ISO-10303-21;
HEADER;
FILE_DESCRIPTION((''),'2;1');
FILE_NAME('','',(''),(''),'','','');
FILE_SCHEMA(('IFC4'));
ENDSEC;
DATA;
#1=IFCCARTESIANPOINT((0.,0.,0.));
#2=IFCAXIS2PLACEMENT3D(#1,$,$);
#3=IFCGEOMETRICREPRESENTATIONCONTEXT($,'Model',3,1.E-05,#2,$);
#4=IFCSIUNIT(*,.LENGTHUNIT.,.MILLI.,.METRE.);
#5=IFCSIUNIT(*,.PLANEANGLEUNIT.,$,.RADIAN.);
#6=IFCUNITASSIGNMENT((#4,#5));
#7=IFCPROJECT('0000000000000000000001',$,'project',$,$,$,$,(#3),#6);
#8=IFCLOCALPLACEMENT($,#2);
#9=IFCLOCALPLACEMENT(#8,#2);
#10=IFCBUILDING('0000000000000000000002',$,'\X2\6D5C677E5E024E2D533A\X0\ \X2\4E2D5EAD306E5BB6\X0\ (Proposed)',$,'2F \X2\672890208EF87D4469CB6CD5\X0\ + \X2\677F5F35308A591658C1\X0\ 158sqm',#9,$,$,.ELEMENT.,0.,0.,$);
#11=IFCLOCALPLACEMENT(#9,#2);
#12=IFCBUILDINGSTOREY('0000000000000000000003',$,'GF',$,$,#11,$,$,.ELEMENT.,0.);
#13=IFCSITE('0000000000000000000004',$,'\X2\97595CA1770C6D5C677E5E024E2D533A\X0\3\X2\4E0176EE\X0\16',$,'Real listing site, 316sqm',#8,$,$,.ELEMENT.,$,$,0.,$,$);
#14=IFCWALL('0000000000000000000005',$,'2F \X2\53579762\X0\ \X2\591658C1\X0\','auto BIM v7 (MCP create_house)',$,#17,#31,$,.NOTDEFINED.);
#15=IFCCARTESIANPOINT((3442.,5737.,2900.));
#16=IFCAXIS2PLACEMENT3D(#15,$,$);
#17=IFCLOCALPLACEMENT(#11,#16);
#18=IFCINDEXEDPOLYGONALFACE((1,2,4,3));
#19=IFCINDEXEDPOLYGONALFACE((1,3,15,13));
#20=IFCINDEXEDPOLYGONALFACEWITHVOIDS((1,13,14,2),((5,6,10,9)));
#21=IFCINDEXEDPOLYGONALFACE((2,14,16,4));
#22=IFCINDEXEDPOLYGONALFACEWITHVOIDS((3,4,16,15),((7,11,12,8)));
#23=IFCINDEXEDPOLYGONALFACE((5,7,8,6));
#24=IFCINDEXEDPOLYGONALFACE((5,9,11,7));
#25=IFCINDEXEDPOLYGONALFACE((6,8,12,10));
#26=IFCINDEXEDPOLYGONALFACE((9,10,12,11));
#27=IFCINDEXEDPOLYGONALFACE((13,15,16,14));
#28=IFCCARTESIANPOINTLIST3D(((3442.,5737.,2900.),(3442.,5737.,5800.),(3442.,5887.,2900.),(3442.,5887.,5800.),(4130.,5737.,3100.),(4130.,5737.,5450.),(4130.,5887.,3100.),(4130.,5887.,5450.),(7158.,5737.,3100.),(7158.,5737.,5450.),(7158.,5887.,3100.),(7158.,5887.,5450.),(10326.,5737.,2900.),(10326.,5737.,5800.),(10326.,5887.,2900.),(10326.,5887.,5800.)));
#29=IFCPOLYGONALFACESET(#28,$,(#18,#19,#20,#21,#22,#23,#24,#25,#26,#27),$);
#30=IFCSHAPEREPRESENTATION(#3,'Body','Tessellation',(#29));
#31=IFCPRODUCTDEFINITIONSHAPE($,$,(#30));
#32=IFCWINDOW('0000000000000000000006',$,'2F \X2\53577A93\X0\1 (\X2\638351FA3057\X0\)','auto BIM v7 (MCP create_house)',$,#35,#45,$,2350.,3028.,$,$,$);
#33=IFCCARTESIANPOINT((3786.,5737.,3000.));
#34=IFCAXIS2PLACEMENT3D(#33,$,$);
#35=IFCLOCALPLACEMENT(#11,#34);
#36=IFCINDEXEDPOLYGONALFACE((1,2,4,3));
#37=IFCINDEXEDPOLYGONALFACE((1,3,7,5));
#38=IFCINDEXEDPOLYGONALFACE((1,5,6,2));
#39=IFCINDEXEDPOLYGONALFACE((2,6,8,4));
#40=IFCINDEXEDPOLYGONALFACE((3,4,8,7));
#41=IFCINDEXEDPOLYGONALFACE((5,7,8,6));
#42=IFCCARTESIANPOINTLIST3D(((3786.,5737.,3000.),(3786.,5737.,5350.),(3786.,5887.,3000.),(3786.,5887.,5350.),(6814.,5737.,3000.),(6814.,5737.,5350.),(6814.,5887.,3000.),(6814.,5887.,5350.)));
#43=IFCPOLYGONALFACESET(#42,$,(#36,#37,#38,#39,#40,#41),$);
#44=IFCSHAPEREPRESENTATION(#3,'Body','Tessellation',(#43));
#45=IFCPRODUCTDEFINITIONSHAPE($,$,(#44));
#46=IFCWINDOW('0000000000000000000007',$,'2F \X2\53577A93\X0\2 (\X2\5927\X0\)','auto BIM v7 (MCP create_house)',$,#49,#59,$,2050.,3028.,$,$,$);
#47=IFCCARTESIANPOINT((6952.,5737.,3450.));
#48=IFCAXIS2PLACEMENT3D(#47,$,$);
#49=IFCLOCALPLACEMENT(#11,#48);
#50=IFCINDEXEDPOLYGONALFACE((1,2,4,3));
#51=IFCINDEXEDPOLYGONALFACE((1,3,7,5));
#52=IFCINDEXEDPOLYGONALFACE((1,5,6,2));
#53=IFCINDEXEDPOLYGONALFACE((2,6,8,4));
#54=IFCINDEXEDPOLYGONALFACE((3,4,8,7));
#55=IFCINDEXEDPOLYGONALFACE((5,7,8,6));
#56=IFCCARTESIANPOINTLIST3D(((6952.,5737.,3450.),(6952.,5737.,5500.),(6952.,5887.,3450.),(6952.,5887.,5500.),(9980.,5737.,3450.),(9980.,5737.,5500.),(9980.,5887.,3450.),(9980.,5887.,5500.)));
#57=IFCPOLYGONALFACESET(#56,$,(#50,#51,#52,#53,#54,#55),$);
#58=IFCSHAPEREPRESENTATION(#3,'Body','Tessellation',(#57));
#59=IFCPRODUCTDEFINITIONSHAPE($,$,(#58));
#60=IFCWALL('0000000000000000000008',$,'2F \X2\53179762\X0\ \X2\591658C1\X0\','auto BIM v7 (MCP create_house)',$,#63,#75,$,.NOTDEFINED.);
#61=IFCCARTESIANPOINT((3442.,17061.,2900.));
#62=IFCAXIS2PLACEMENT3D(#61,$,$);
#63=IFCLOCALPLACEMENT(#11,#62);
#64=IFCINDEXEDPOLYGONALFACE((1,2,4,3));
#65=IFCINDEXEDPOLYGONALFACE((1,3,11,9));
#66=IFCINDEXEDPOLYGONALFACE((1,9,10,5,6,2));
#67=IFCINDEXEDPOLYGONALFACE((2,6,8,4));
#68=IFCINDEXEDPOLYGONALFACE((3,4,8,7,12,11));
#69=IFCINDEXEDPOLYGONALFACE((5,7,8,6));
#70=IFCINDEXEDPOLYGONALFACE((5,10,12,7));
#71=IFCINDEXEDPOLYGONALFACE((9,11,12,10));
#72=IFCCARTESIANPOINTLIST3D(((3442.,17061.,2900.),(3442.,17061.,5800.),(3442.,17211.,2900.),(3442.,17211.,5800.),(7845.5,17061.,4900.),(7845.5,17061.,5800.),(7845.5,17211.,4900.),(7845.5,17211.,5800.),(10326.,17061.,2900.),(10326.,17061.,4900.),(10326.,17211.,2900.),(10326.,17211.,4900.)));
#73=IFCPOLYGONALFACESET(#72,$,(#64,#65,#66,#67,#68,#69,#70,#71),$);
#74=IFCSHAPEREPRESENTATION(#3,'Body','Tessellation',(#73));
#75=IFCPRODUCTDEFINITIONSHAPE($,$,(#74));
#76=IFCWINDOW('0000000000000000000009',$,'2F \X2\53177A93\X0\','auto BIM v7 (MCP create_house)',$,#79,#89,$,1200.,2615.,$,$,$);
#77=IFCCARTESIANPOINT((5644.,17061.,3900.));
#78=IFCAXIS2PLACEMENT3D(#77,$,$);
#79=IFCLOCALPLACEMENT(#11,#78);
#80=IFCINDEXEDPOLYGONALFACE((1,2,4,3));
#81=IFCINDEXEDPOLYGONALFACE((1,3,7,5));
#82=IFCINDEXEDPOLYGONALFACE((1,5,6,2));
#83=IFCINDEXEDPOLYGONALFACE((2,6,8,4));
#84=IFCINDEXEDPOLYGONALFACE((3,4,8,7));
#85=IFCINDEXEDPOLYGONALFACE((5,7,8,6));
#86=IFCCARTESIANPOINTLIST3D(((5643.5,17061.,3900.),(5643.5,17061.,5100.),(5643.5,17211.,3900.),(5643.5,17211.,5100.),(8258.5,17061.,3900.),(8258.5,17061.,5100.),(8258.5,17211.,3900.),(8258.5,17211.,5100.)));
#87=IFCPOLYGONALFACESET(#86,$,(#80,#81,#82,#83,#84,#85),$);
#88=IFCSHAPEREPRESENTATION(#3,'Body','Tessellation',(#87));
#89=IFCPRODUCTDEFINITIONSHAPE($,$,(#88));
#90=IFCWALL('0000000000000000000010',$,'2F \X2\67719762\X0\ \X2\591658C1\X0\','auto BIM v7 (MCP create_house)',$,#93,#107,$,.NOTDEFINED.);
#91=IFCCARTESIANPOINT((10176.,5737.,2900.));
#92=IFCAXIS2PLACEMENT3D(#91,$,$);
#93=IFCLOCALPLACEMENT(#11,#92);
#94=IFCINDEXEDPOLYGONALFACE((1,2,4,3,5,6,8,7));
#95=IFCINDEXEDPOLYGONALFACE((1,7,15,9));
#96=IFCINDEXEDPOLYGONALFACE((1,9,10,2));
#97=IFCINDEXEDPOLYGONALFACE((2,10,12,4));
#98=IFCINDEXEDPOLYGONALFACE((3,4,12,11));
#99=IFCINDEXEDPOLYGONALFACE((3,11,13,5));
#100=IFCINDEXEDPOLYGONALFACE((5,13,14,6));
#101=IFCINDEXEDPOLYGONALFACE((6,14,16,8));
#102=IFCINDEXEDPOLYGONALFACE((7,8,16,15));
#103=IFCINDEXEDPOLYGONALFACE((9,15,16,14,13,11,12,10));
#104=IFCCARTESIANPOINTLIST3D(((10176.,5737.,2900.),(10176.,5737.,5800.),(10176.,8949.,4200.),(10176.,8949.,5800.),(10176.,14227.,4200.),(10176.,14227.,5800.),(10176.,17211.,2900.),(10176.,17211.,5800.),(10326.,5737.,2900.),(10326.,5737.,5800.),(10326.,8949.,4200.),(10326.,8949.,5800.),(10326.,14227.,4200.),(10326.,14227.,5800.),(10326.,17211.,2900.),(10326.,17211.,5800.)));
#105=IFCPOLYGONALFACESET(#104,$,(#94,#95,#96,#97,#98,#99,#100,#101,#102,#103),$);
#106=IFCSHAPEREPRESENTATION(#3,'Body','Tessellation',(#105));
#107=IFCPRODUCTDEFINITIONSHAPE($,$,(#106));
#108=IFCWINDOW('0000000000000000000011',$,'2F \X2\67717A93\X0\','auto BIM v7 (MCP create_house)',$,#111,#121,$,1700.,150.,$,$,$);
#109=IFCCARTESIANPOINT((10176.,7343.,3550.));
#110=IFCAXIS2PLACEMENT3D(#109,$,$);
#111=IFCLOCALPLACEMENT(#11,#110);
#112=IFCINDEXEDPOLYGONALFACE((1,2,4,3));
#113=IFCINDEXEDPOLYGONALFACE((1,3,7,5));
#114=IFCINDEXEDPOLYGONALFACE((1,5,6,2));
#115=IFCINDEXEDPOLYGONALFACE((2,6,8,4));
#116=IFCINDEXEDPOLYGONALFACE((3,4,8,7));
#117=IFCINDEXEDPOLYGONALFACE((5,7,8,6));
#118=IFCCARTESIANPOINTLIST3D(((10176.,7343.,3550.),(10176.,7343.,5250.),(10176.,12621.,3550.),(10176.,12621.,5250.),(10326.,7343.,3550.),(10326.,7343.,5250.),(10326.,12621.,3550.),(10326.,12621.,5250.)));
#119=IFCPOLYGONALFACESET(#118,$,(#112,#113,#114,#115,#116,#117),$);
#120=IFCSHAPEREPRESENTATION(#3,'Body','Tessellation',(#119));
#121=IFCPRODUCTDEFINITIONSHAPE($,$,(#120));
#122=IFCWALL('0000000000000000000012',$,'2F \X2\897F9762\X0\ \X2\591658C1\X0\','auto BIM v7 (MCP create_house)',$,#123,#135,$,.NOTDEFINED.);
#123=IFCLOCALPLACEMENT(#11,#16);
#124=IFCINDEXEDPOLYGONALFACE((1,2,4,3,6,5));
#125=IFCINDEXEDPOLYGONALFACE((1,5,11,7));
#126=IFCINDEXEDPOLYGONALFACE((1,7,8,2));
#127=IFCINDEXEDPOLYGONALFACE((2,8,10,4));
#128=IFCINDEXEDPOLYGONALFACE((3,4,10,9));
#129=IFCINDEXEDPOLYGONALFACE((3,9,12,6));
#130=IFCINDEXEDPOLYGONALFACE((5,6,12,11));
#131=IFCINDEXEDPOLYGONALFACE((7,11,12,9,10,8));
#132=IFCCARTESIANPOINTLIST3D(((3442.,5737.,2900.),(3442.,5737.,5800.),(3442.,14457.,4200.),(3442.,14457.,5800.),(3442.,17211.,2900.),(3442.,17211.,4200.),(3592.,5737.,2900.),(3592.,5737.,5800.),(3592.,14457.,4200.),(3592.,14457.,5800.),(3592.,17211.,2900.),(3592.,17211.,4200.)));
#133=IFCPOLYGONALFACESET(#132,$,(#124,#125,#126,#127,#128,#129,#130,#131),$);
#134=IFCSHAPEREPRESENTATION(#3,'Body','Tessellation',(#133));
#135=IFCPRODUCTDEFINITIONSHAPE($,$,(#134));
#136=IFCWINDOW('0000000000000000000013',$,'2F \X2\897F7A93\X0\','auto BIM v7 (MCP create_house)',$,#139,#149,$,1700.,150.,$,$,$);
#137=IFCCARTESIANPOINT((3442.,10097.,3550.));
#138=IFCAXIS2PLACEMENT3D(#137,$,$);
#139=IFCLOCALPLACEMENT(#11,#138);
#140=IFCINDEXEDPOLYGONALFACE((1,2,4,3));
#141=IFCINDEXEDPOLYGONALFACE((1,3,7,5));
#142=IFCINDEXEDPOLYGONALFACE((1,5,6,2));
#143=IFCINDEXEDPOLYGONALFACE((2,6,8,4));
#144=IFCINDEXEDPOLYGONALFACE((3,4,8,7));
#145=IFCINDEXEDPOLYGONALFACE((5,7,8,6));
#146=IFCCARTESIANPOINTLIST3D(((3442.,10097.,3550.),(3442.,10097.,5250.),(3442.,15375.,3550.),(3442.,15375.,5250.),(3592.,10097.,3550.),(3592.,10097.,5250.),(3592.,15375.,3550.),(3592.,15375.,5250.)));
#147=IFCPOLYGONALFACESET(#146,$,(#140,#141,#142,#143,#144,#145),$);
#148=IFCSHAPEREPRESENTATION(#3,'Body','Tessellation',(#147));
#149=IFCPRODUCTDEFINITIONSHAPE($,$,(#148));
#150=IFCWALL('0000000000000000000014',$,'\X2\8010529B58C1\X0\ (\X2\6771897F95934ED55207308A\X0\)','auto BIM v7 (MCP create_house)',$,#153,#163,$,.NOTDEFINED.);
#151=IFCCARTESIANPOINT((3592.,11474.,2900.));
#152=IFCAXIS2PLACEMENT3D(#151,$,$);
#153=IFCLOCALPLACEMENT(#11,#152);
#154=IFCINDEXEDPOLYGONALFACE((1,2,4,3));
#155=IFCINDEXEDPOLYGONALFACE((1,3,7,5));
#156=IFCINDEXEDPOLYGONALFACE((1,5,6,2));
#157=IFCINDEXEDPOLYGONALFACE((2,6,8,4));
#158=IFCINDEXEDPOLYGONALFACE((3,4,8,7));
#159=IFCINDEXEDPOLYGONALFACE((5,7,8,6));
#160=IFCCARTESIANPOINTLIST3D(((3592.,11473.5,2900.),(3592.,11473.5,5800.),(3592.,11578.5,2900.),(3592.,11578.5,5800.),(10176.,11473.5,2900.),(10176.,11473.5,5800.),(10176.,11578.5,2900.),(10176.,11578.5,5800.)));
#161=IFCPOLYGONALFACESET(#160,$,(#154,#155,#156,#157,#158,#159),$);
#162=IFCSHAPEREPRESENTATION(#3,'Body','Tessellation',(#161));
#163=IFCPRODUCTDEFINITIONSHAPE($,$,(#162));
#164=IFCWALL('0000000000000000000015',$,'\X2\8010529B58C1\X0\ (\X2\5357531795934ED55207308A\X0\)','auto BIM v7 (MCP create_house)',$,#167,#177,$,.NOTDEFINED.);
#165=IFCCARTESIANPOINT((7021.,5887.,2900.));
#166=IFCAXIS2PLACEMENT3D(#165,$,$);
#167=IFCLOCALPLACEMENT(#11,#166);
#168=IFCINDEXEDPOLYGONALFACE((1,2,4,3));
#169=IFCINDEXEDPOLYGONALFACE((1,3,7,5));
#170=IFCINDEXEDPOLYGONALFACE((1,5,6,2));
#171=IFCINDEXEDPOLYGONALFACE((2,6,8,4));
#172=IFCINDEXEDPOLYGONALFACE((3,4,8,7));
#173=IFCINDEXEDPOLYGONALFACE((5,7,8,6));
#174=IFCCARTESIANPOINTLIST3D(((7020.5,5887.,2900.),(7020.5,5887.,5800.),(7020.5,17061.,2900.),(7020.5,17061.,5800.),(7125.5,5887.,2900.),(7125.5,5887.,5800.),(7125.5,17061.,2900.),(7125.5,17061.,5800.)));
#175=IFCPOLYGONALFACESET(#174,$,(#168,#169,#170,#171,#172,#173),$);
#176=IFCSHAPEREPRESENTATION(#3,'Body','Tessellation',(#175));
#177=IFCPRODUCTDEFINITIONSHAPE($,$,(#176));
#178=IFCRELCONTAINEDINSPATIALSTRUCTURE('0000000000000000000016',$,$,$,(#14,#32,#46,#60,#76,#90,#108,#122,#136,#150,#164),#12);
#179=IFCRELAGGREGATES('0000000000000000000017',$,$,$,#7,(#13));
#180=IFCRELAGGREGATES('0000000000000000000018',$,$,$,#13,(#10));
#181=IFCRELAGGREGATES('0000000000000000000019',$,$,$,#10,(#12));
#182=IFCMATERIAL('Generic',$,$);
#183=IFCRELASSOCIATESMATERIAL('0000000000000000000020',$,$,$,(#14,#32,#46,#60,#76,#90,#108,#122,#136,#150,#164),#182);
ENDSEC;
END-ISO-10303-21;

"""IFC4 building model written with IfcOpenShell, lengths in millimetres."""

from ifc_helpers import new_model, si_unit, frame, frame_2d, origin, place, context, project, spatial, rectangle, extrude, material, element, fill, save


model = new_model("IFC4")

# Units and contexts
model_context = context("Model", 3, precision=1e-05, world=origin())
ifc_project = project(units=[si_unit("LENGTHUNIT", "METRE", prefix="MILLI"), si_unit("PLANEANGLEUNIT", "RADIAN")], contexts=[model_context])

# Site, building, storey
site_placement = place(None, origin())
site = spatial("IfcSite", under=ifc_project, at=site_placement, Name="静岡県浜松市中区3丁目16", ObjectType="Real listing site, 316sqm", CompositionType="ELEMENT", RefElevation=0.0)
building_placement = place(site_placement, origin())
building = spatial("IfcBuilding", under=site, at=building_placement, Name="浜松市中区 中庭の家 (Proposed)", ObjectType="2F 木造軸組構法 + 板張り外壁 158sqm", CompositionType="ELEMENT", ElevationOfRefHeight=0.0, ElevationOfTerrain=0.0)
storey_placement = place(building_placement, origin())
storey = spatial("IfcBuildingStorey", under=building, at=storey_placement, Name="GF", CompositionType="ELEMENT", Elevation=0.0)

# Shared definitions
ifc_material = material(Name="Generic")

# Wall, openings, windows
wall_1_placement = place(storey_placement, frame((3442.0, 5737.0, 2900.0)))
wall_1 = element("IfcWall", 1, at=wall_1_placement, inside=storey, material=ifc_material, Name="2F 南面 外壁", Description="auto BIM v7 (MCP create_house)", PredefinedType="NOTDEFINED", context=model_context, shape_type="SweptSolid", body=[
    extrude(rectangle(XDim=6884.0, YDim=150.0, at=frame_2d((3442.0, 75.0))), frame((3442.0, 5737.0, 2900.0)), (0.0, 0.0, 1.0), 2900.0),
])
opening_1_placement = place(storey_placement, frame((3786.0, 5737.0, 3000.0)))
opening_1 = element("IfcOpeningElement", 2, at=opening_1_placement, cuts=wall_1, PredefinedType="NOTDEFINED", context=model_context, shape_type="SweptSolid", body=[
    extrude(rectangle(XDim=3028.0, YDim=150.0, at=frame_2d((1514.0, 75.0))), frame((3786.0, 5737.0, 3000.0)), (0.0, 0.0, 1.0), 2350.0),
])
opening_2_placement = place(storey_placement, frame((6952.0, 5737.0, 3450.0)))
opening_2 = element("IfcOpeningElement", 3, at=opening_2_placement, cuts=wall_1, PredefinedType="NOTDEFINED", context=model_context, shape_type="SweptSolid", body=[
    extrude(rectangle(XDim=3028.0, YDim=150.0, at=frame_2d((1514.0, 75.0))), frame((6952.0, 5737.0, 3450.0)), (0.0, 0.0, 1.0), 2050.0),
])
window_1_placement = place(storey_placement, frame((3786.0, 5737.0, 3000.0)))
window_1 = element("IfcWindow", 4, at=window_1_placement, inside=storey, material=ifc_material, Name="2F 南窓1 (掃出し)", Description="auto BIM v7 (MCP create_house)", OverallHeight=2350.0, OverallWidth=3028.0, context=model_context, shape_type="SweptSolid", body=[
    extrude(rectangle(XDim=3028.0, YDim=150.0, at=frame_2d((1514.0, 75.0))), frame((3786.0, 5737.0, 3000.0)), (0.0, 0.0, 1.0), 2350.0),
])
fill(opening_1, window_1)
window_2_placement = place(storey_placement, frame((6952.0, 5737.0, 3450.0)))
window_2 = element("IfcWindow", 5, at=window_2_placement, inside=storey, material=ifc_material, Name="2F 南窓2 (大)", Description="auto BIM v7 (MCP create_house)", OverallHeight=2050.0, OverallWidth=3028.0, context=model_context, shape_type="SweptSolid", body=[
    extrude(rectangle(XDim=3028.0, YDim=150.0, at=frame_2d((1514.0, 75.0))), frame((6952.0, 5737.0, 3450.0)), (0.0, 0.0, 1.0), 2050.0),
])
fill(opening_2, window_2)

# Walls, openings, windows
wall_2_placement = place(storey_placement, frame((3442.0, 17061.0, 2900.0)))
wall_2 = element("IfcWall", 6, at=wall_2_placement, inside=storey, material=ifc_material, Name="2F 北面 外壁", Description="auto BIM v7 (MCP create_house)", PredefinedType="NOTDEFINED", context=model_context, shape_type="SweptSolid", body=[
    extrude(rectangle(XDim=6884.0, YDim=150.0, at=frame_2d((3442.0, 75.0))), frame((3442.0, 17061.0, 2900.0)), (0.0, 0.0, 1.0), 2900.0),
])
opening_3_placement = place(storey_placement, frame((5644.0, 17061.0, 3900.0)))
opening_3 = element("IfcOpeningElement", 7, at=opening_3_placement, cuts=wall_2, PredefinedType="NOTDEFINED", context=model_context, shape_type="SweptSolid", body=[
    extrude(rectangle(XDim=2615.0, YDim=150.0, at=frame_2d((1307.0, 75.0))), frame((5644.0, 17061.0, 3900.0)), (0.0, 0.0, 1.0), 1200.0),
])
window_3_placement = place(storey_placement, frame((5644.0, 17061.0, 3900.0)))
window_3 = element("IfcWindow", 8, at=window_3_placement, inside=storey, material=ifc_material, Name="2F 北窓", Description="auto BIM v7 (MCP create_house)", OverallHeight=1200.0, OverallWidth=2615.0, context=model_context, shape_type="SweptSolid", body=[
    extrude(rectangle(XDim=2615.0, YDim=150.0, at=frame_2d((1307.0, 75.0))), frame((5644.0, 17061.0, 3900.0)), (0.0, 0.0, 1.0), 1200.0),
])
fill(opening_3, window_3)
wall_3_placement = place(storey_placement, frame((10176.0, 5737.0, 2900.0)))
wall_3 = element("IfcWall", 9, at=wall_3_placement, inside=storey, material=ifc_material, Name="2F 東面 外壁", Description="auto BIM v7 (MCP create_house)", PredefinedType="NOTDEFINED", context=model_context, shape_type="SweptSolid", body=[
    extrude(rectangle(XDim=150.0, YDim=11474.0, at=frame_2d((75.0, 5737.0))), frame((10176.0, 5737.0, 2900.0)), (0.0, 0.0, 1.0), 2900.0),
])
opening_4_placement = place(storey_placement, frame((10176.0, 7343.0, 3550.0)))
opening_4 = element("IfcOpeningElement", 10, at=opening_4_placement, cuts=wall_3, PredefinedType="NOTDEFINED", context=model_context, shape_type="SweptSolid", body=[
    extrude(rectangle(XDim=150.0, YDim=5278.0, at=frame_2d((75.0, 2639.0))), frame((10176.0, 7343.0, 3550.0)), (0.0, 0.0, 1.0), 1700.0),
])
window_4_placement = place(storey_placement, frame((10176.0, 7343.0, 3550.0)))
window_4 = element("IfcWindow", 11, at=window_4_placement, inside=storey, material=ifc_material, Name="2F 東窓", Description="auto BIM v7 (MCP create_house)", OverallHeight=1700.0, OverallWidth=150.0, context=model_context, shape_type="SweptSolid", body=[
    extrude(rectangle(XDim=150.0, YDim=5278.0, at=frame_2d((75.0, 2639.0))), frame((10176.0, 7343.0, 3550.0)), (0.0, 0.0, 1.0), 1700.0),
])
fill(opening_4, window_4)
wall_4_placement = place(storey_placement, frame((3442.0, 5737.0, 2900.0)))
wall_4 = element("IfcWall", 12, at=wall_4_placement, inside=storey, material=ifc_material, Name="2F 西面 外壁", Description="auto BIM v7 (MCP create_house)", PredefinedType="NOTDEFINED", context=model_context, shape_type="SweptSolid", body=[
    extrude(rectangle(XDim=150.0, YDim=11474.0, at=frame_2d((75.0, 5737.0))), frame((3442.0, 5737.0, 2900.0)), (0.0, 0.0, 1.0), 2900.0),
])
opening_5_placement = place(storey_placement, frame((3442.0, 10097.0, 3550.0)))
opening_5 = element("IfcOpeningElement", 13, at=opening_5_placement, cuts=wall_4, PredefinedType="NOTDEFINED", context=model_context, shape_type="SweptSolid", body=[
    extrude(rectangle(XDim=150.0, YDim=5278.0, at=frame_2d((75.0, 2639.0))), frame((3442.0, 10097.0, 3550.0)), (0.0, 0.0, 1.0), 1700.0),
])
window_5_placement = place(storey_placement, frame((3442.0, 10097.0, 3550.0)))
window_5 = element("IfcWindow", 14, at=window_5_placement, inside=storey, material=ifc_material, Name="2F 西窓", Description="auto BIM v7 (MCP create_house)", OverallHeight=1700.0, OverallWidth=150.0, context=model_context, shape_type="SweptSolid", body=[
    extrude(rectangle(XDim=150.0, YDim=5278.0, at=frame_2d((75.0, 2639.0))), frame((3442.0, 10097.0, 3550.0)), (0.0, 0.0, 1.0), 1700.0),
])
fill(opening_5, window_5)

# Walls
wall_5_placement = place(storey_placement, frame((3592.0, 11474.0, 2900.0)))
element("IfcWall", 15, at=wall_5_placement, inside=storey, material=ifc_material, Name="耐力壁 (東西間仕切り)", Description="auto BIM v7 (MCP create_house)", PredefinedType="NOTDEFINED", context=model_context, shape_type="SweptSolid", body=[
    extrude(rectangle(XDim=6584.0, YDim=105.0, at=frame_2d((3292.0, 52.0))), frame((3592.0, 11474.0, 2900.0)), (0.0, 0.0, 1.0), 2900.0),
])
wall_6_placement = place(storey_placement, frame((7021.0, 5887.0, 2900.0)))
element("IfcWall", 16, at=wall_6_placement, inside=storey, material=ifc_material, Name="耐力壁 (南北間仕切り)", Description="auto BIM v7 (MCP create_house)", PredefinedType="NOTDEFINED", context=model_context, shape_type="SweptSolid", body=[
    extrude(rectangle(XDim=105.0, YDim=11174.0, at=frame_2d((52.0, 5587.0))), frame((7021.0, 5887.0, 2900.0)), (0.0, 0.0, 1.0), 2900.0),
])

save(model, "model.ifc")
